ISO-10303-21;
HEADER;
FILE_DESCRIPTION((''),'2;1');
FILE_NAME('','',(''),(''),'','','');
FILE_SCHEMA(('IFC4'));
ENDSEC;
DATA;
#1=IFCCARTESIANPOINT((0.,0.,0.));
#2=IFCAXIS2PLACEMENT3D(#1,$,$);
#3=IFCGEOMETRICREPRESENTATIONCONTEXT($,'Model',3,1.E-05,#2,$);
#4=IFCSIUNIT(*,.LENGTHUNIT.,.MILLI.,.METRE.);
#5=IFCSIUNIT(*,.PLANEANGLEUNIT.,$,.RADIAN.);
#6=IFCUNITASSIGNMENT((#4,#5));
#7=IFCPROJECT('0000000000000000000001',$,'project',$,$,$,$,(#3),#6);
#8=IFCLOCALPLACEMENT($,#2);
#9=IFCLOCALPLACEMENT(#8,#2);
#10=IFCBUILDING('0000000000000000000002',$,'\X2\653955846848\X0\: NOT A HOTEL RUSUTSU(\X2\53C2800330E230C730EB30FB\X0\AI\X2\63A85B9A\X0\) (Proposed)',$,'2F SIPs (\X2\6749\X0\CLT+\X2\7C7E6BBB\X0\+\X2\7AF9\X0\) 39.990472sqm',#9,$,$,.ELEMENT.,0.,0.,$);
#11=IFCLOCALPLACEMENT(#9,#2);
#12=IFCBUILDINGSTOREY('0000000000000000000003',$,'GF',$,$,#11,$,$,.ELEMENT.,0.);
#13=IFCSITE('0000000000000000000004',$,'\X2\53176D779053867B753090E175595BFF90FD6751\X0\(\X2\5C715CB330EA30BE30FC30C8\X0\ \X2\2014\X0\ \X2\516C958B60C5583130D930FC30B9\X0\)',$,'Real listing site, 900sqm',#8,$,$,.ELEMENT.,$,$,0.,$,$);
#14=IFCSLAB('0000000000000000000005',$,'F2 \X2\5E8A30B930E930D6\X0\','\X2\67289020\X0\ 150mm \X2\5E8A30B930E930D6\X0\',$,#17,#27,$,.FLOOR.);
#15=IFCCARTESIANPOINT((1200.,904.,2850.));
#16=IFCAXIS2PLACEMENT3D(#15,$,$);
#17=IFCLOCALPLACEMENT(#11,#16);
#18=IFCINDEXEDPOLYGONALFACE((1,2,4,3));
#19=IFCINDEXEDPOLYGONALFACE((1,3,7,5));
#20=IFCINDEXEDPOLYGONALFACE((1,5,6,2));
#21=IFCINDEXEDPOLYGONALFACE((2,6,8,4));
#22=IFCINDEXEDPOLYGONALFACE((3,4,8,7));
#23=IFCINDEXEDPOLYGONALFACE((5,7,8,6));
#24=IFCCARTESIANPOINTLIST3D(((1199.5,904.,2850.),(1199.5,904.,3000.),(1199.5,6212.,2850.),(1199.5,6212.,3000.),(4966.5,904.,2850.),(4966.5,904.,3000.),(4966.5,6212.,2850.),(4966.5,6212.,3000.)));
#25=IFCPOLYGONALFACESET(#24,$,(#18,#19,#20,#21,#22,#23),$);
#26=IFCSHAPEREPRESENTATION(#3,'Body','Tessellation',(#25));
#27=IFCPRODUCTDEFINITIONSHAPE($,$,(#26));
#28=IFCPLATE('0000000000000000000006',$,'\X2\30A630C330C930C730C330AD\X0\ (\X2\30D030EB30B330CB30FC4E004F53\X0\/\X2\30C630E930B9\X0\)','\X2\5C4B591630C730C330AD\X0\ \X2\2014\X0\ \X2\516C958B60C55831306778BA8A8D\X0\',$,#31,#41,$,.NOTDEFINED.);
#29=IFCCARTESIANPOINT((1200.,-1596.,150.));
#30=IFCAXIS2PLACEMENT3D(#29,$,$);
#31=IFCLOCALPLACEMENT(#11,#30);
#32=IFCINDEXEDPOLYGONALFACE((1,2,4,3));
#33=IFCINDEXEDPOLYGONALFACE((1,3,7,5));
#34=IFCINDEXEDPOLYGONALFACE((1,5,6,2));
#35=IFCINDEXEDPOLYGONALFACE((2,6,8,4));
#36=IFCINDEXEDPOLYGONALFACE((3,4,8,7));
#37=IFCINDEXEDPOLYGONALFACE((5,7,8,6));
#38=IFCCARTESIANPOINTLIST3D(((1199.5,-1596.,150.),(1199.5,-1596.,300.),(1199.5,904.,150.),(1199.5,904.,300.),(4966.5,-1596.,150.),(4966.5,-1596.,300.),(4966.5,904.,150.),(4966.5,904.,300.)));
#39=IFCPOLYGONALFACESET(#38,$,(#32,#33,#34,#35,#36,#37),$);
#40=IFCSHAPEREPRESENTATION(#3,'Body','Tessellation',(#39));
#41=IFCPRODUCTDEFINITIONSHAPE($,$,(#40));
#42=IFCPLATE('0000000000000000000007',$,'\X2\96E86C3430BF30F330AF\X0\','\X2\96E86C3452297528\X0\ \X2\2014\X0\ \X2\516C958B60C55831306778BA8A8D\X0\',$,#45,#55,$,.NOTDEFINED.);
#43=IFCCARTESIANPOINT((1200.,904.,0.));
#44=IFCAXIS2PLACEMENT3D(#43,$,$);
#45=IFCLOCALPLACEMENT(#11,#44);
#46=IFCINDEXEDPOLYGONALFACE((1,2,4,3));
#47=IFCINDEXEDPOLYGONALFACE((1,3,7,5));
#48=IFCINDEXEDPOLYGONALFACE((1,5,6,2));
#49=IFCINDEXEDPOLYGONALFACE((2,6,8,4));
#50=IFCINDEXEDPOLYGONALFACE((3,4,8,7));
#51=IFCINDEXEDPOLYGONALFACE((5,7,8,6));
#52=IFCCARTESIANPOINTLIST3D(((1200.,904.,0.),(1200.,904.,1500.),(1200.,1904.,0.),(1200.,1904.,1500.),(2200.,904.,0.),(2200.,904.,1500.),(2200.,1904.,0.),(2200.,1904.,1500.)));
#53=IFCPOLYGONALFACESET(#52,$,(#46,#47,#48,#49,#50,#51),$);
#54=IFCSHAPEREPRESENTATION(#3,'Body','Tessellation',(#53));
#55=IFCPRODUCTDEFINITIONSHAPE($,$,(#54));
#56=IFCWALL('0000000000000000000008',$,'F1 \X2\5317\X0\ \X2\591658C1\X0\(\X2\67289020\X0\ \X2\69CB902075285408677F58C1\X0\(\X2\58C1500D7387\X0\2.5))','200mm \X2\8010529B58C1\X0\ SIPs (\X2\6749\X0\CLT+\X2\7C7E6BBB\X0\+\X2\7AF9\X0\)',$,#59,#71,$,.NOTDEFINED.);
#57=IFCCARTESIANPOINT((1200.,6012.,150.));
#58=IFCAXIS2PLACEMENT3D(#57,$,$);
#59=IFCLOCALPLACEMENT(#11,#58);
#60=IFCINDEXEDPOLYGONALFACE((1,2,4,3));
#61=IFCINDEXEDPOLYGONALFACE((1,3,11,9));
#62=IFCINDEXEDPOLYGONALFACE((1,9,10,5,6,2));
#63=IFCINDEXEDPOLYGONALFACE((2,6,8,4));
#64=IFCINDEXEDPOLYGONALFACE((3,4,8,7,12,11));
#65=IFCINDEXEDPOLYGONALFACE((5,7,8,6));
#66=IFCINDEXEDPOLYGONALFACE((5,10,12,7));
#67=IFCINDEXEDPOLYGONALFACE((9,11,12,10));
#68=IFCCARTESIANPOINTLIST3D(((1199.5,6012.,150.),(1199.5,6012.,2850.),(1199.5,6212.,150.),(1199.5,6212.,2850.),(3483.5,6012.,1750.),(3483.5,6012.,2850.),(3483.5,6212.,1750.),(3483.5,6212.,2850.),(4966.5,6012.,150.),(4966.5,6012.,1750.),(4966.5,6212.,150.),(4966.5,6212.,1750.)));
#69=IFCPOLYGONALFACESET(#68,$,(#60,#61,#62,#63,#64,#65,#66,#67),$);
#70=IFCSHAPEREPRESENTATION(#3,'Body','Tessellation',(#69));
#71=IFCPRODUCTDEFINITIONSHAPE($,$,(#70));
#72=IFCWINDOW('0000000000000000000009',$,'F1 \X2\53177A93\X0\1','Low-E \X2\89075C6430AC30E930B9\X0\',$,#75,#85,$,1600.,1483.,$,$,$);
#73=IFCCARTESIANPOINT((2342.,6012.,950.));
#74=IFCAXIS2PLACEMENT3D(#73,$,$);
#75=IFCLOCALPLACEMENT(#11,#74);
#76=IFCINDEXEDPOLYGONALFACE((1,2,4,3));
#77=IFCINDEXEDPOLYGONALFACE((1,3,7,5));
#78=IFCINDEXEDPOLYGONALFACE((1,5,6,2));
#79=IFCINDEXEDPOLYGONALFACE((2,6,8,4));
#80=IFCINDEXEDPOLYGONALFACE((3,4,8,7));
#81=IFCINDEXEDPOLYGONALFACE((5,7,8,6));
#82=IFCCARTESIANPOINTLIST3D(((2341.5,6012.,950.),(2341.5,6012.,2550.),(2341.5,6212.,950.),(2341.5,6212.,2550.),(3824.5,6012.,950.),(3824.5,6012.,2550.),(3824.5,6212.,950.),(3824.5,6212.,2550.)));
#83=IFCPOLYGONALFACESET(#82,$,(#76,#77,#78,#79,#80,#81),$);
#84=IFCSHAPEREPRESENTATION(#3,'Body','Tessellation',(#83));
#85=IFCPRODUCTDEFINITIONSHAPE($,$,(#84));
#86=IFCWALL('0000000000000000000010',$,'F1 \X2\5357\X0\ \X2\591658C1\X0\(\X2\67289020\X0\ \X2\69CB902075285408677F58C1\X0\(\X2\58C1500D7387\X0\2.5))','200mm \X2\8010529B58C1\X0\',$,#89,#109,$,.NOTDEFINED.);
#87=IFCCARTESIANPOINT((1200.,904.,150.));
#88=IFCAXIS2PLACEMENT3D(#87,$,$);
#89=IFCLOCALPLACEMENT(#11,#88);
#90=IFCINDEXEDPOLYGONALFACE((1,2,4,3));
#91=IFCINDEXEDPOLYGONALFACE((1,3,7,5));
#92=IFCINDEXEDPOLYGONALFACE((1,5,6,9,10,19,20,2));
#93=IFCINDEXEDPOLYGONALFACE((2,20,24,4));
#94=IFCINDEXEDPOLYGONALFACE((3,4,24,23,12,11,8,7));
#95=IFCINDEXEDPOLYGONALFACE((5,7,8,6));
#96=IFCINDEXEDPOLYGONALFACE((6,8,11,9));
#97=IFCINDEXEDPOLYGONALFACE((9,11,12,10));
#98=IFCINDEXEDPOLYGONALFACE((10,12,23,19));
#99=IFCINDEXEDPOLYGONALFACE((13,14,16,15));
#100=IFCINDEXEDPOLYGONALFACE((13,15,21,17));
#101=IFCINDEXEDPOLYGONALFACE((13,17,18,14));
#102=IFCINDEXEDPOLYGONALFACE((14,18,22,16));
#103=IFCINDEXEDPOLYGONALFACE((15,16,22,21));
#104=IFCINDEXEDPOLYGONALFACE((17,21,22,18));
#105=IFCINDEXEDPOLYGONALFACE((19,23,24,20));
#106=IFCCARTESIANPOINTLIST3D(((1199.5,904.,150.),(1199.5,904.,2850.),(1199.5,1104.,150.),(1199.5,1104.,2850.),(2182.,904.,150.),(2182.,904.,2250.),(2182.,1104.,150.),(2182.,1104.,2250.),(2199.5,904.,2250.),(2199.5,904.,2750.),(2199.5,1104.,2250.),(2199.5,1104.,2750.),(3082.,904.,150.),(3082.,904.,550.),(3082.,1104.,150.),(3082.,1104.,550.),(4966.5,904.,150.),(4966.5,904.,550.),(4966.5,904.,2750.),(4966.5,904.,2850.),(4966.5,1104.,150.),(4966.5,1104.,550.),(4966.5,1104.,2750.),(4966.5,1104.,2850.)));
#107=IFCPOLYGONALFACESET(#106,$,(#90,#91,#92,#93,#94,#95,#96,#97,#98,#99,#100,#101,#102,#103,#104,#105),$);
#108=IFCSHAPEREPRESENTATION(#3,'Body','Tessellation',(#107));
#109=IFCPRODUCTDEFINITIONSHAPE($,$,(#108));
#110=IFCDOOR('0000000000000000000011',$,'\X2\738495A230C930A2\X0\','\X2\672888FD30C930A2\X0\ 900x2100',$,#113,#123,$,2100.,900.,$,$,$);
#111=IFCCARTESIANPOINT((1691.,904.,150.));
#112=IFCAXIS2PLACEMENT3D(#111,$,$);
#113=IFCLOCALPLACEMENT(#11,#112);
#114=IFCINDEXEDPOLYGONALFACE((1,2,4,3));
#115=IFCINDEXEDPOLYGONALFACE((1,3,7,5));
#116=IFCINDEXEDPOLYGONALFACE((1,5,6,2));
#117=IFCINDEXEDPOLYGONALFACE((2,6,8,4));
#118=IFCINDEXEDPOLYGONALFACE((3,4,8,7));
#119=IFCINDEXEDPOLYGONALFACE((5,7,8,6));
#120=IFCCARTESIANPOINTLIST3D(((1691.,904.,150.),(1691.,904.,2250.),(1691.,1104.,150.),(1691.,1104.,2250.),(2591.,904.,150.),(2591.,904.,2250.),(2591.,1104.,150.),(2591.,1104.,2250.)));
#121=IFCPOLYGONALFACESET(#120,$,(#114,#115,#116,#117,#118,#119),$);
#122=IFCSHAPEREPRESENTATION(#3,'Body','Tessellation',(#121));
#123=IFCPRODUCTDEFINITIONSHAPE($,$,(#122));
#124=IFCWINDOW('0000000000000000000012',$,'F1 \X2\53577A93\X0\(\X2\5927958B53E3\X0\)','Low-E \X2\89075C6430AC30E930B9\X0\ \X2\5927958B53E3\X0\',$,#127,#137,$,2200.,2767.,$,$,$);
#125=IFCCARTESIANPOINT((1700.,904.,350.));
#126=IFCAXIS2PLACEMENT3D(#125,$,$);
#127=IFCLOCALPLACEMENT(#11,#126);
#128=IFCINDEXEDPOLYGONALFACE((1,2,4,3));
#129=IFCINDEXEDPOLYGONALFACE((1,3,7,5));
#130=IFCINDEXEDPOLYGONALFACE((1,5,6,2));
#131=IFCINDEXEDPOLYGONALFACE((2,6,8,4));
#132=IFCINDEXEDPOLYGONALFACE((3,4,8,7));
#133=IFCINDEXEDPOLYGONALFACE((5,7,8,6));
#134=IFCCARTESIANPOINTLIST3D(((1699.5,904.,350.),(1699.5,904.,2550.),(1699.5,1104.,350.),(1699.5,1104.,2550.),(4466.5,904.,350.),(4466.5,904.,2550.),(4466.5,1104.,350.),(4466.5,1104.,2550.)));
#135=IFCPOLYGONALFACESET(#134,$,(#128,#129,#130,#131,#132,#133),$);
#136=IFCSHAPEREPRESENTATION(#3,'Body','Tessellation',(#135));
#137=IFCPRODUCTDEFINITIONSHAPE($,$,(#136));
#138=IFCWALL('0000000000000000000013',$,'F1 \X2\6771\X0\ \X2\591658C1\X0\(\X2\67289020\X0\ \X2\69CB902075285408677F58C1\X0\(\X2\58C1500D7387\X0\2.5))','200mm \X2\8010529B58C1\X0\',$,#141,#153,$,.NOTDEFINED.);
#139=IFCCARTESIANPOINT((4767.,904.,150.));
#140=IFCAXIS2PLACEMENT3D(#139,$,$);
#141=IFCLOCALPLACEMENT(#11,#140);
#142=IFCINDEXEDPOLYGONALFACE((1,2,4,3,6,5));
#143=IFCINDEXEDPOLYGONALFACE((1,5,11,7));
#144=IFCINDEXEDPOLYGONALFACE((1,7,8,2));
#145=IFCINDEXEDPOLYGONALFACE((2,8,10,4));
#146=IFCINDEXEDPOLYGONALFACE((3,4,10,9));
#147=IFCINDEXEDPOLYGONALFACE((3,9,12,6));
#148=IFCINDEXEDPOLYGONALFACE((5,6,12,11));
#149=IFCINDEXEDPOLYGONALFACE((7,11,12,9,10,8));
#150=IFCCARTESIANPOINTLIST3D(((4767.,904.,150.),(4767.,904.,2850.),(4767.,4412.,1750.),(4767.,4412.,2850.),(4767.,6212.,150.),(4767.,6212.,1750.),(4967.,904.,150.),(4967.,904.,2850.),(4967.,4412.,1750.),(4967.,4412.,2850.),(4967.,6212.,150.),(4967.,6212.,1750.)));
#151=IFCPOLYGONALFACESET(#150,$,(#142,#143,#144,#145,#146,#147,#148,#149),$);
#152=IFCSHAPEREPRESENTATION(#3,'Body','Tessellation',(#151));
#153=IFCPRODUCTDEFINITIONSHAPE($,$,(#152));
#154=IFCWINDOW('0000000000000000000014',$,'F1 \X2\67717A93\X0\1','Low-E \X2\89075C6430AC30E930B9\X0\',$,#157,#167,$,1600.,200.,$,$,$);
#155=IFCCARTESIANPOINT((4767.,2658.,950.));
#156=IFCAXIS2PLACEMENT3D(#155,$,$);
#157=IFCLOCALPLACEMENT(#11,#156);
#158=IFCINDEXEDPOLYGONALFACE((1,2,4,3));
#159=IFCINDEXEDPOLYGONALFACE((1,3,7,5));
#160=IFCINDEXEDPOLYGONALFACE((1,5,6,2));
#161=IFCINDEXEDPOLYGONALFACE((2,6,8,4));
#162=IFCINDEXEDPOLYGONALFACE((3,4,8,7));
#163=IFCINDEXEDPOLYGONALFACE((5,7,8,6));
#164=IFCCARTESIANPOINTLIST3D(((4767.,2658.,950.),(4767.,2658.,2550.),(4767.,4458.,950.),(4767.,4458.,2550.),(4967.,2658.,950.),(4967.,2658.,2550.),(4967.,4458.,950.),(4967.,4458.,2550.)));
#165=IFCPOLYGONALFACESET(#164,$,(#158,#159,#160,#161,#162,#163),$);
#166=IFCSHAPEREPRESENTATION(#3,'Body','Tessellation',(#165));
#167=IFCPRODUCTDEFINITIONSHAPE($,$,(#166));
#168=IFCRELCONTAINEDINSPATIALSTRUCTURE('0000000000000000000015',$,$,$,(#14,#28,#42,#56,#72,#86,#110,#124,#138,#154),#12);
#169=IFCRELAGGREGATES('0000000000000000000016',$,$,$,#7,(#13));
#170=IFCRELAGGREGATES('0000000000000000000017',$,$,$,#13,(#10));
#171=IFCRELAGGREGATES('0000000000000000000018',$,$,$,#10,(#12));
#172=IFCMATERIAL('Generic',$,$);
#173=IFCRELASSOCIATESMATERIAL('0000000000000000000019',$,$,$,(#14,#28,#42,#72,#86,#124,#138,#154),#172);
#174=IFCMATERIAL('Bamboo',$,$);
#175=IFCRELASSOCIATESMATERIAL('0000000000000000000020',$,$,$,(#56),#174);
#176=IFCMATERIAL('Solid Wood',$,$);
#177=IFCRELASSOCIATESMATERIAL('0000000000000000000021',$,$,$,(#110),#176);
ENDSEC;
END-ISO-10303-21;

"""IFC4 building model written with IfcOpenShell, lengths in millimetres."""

from ifc_helpers import new_model, si_unit, frame, frame_2d, origin, place, context, project, spatial, rectangle, extrude, material, element, fill, save


model = new_model("IFC4")

# Units and contexts
model_context = context("Model", 3, precision=1e-05, world=origin())
ifc_project = project(units=[si_unit("LENGTHUNIT", "METRE", prefix="MILLI"), si_unit("PLANEANGLEUNIT", "RADIAN")], contexts=[model_context])

# Site, building, storey
site_placement = place(None, origin())
site = spatial("IfcSite", under=ifc_project, at=site_placement, Name="北海道虻田郡留寿都村(山岳リゾート — 公開情報ベース)", ObjectType="Real listing site, 900sqm", CompositionType="ELEMENT", RefElevation=0.0)
building_placement = place(site_placement, origin())
building = spatial("IfcBuilding", under=site, at=building_placement, Name="改善案: NOT A HOTEL RUSUTSU(参考モデル・AI推定) (Proposed)", ObjectType="2F SIPs (杉CLT+籾殻+竹) 39.990472sqm", CompositionType="ELEMENT", ElevationOfRefHeight=0.0, ElevationOfTerrain=0.0)
storey_placement = place(building_placement, origin())
storey = spatial("IfcBuildingStorey", under=building, at=storey_placement, Name="GF", CompositionType="ELEMENT", Elevation=0.0)

# Slab
ifc_material_1 = material(Name="Generic")
slab_1_placement = place(storey_placement, frame((1200.0, 904.0, 2850.0)))
element("IfcSlab", 1, at=slab_1_placement, inside=storey, material=ifc_material_1, Name="F2 床スラブ", Description="木造 150mm 床スラブ", PredefinedType="FLOOR", context=model_context, shape_type="SweptSolid", body=[
    extrude(rectangle(XDim=3767.0, YDim=5308.0, at=frame_2d((1883.0, 2654.0))), frame((1200.0, 904.0, 2850.0)), (0.0, 0.0, 1.0), 150.0),
])

# Plates
plate_1_placement = place(storey_placement, frame((1200.0, -1596.0, 150.0)))
element("IfcPlate", 2, at=plate_1_placement, inside=storey, material=ifc_material_1, Name="ウッドデッキ (バルコニー一体/テラス)", Description="屋外デッキ — 公開情報で確認", PredefinedType="NOTDEFINED", context=model_context, shape_type="SweptSolid", body=[
    extrude(rectangle(XDim=3767.0, YDim=2500.0, at=frame_2d((1883.0, 1250.0))), frame((1200.0, -1596.0, 150.0)), (0.0, 0.0, 1.0), 150.0),
])
plate_2_placement = place(storey_placement, frame((1200.0, 904.0, 0.0)))
element("IfcPlate", 3, at=plate_2_placement, inside=storey, material=ifc_material_1, Name="雨水タンク", Description="雨水利用 — 公開情報で確認", PredefinedType="NOTDEFINED", context=model_context, shape_type="SweptSolid", body=[
    extrude(rectangle(XDim=1000.0, YDim=1000.0, at=frame_2d((500.0, 500.0))), frame((1200.0, 904.0, 0.0)), (0.0, 0.0, 1.0), 1500.0),
])

# Wall, opening, window
ifc_material_2 = material(Name="Bamboo")
wall_1_placement = place(storey_placement, frame((1200.0, 6012.0, 150.0)))
wall_1 = element("IfcWall", 4, at=wall_1_placement, inside=storey, material=ifc_material_2, Name="F1 北 外壁(木造 構造用合板壁(壁倍率2.5))", Description="200mm 耐力壁 SIPs (杉CLT+籾殻+竹)", PredefinedType="NOTDEFINED", context=model_context, shape_type="SweptSolid", body=[
    extrude(rectangle(XDim=3767.0, YDim=200.0, at=frame_2d((1883.0, 100.0))), frame((1200.0, 6012.0, 150.0)), (0.0, 0.0, 1.0), 2700.0),
])
opening_1_placement = place(storey_placement, frame((2342.0, 6012.0, 950.0)))
opening_1 = element("IfcOpeningElement", 5, at=opening_1_placement, cuts=wall_1, PredefinedType="NOTDEFINED", context=model_context, shape_type="SweptSolid", body=[
    extrude(rectangle(XDim=1483.0, YDim=200.0, at=frame_2d((741.0, 100.0))), frame((2342.0, 6012.0, 950.0)), (0.0, 0.0, 1.0), 1600.0),
])
window_1_placement = place(storey_placement, frame((2342.0, 6012.0, 950.0)))
window_1 = element("IfcWindow", 6, at=window_1_placement, inside=storey, material=ifc_material_1, Name="F1 北窓1", Description="Low-E 複層ガラス", OverallHeight=1600.0, OverallWidth=1483.0, context=model_context, shape_type="SweptSolid", body=[
    extrude(rectangle(XDim=1483.0, YDim=200.0, at=frame_2d((741.0, 100.0))), frame((2342.0, 6012.0, 950.0)), (0.0, 0.0, 1.0), 1600.0),
])
fill(opening_1, window_1)

# Wall, openings, door, window
wall_2_placement = place(storey_placement, frame((1200.0, 904.0, 150.0)))
wall_2 = element("IfcWall", 7, at=wall_2_placement, inside=storey, material=ifc_material_1, Name="F1 南 外壁(木造 構造用合板壁(壁倍率2.5))", Description="200mm 耐力壁", PredefinedType="NOTDEFINED", context=model_context, shape_type="SweptSolid", body=[
    extrude(rectangle(XDim=3767.0, YDim=200.0, at=frame_2d((1883.0, 100.0))), frame((1200.0, 904.0, 150.0)), (0.0, 0.0, 1.0), 2700.0),
])
opening_2_placement = place(storey_placement, frame((1691.0, 904.0, 150.0)))
opening_2 = element("IfcOpeningElement", 8, at=opening_2_placement, cuts=wall_2, PredefinedType="NOTDEFINED", context=model_context, shape_type="SweptSolid", body=[
    extrude(rectangle(XDim=900.0, YDim=200.0, at=frame_2d((450.0, 100.0))), frame((1691.0, 904.0, 150.0)), (0.0, 0.0, 1.0), 2100.0),
])
opening_3_placement = place(storey_placement, frame((1700.0, 904.0, 350.0)))
opening_3 = element("IfcOpeningElement", 9, at=opening_3_placement, cuts=wall_2, PredefinedType="NOTDEFINED", context=model_context, shape_type="SweptSolid", body=[
    extrude(rectangle(XDim=2767.0, YDim=200.0, at=frame_2d((1383.0, 100.0))), frame((1700.0, 904.0, 350.0)), (0.0, 0.0, 1.0), 2200.0),
])
ifc_material_3 = material(Name="Solid Wood")
door_placement = place(storey_placement, frame((1691.0, 904.0, 150.0)))
door = element("IfcDoor", 10, at=door_placement, inside=storey, material=ifc_material_3, Name="玄関ドア", Description="木製ドア 900x2100", OverallHeight=2100.0, OverallWidth=900.0, context=model_context, shape_type="SweptSolid", body=[
    extrude(rectangle(XDim=900.0, YDim=200.0, at=frame_2d((450.0, 100.0))), frame((1691.0, 904.0, 150.0)), (0.0, 0.0, 1.0), 2100.0),
])
fill(opening_2, door)
window_2_placement = place(storey_placement, frame((1700.0, 904.0, 350.0)))
window_2 = element("IfcWindow", 11, at=window_2_placement, inside=storey, material=ifc_material_1, Name="F1 南窓(大開口)", Description="Low-E 複層ガラス 大開口", OverallHeight=2200.0, OverallWidth=2767.0, context=model_context, shape_type="SweptSolid", body=[
    extrude(rectangle(XDim=2767.0, YDim=200.0, at=frame_2d((1383.0, 100.0))), frame((1700.0, 904.0, 350.0)), (0.0, 0.0, 1.0), 2200.0),
])
fill(opening_3, window_2)

# Wall, opening, window
wall_3_placement = place(storey_placement, frame((4767.0, 904.0, 150.0)))
wall_3 = element("IfcWall", 12, at=wall_3_placement, inside=storey, material=ifc_material_1, Name="F1 東 外壁(木造 構造用合板壁(壁倍率2.5))", Description="200mm 耐力壁", PredefinedType="NOTDEFINED", context=model_context, shape_type="SweptSolid", body=[
    extrude(rectangle(XDim=200.0, YDim=5308.0, at=frame_2d((100.0, 2654.0))), frame((4767.0, 904.0, 150.0)), (0.0, 0.0, 1.0), 2700.0),
])
opening_4_placement = place(storey_placement, frame((4767.0, 2658.0, 950.0)))
opening_4 = element("IfcOpeningElement", 13, at=opening_4_placement, cuts=wall_3, PredefinedType="NOTDEFINED", context=model_context, shape_type="SweptSolid", body=[
    extrude(rectangle(XDim=200.0, YDim=1800.0, at=frame_2d((100.0, 900.0))), frame((4767.0, 2658.0, 950.0)), (0.0, 0.0, 1.0), 1600.0),
])
window_3_placement = place(storey_placement, frame((4767.0, 2658.0, 950.0)))
window_3 = element("IfcWindow", 14, at=window_3_placement, inside=storey, material=ifc_material_1, Name="F1 東窓1", Description="Low-E 複層ガラス", OverallHeight=1600.0, OverallWidth=200.0, context=model_context, shape_type="SweptSolid", body=[
    extrude(rectangle(XDim=200.0, YDim=1800.0, at=frame_2d((100.0, 900.0))), frame((4767.0, 2658.0, 950.0)), (0.0, 0.0, 1.0), 1600.0),
])
fill(opening_4, window_3)

save(model, "model.ifc")
